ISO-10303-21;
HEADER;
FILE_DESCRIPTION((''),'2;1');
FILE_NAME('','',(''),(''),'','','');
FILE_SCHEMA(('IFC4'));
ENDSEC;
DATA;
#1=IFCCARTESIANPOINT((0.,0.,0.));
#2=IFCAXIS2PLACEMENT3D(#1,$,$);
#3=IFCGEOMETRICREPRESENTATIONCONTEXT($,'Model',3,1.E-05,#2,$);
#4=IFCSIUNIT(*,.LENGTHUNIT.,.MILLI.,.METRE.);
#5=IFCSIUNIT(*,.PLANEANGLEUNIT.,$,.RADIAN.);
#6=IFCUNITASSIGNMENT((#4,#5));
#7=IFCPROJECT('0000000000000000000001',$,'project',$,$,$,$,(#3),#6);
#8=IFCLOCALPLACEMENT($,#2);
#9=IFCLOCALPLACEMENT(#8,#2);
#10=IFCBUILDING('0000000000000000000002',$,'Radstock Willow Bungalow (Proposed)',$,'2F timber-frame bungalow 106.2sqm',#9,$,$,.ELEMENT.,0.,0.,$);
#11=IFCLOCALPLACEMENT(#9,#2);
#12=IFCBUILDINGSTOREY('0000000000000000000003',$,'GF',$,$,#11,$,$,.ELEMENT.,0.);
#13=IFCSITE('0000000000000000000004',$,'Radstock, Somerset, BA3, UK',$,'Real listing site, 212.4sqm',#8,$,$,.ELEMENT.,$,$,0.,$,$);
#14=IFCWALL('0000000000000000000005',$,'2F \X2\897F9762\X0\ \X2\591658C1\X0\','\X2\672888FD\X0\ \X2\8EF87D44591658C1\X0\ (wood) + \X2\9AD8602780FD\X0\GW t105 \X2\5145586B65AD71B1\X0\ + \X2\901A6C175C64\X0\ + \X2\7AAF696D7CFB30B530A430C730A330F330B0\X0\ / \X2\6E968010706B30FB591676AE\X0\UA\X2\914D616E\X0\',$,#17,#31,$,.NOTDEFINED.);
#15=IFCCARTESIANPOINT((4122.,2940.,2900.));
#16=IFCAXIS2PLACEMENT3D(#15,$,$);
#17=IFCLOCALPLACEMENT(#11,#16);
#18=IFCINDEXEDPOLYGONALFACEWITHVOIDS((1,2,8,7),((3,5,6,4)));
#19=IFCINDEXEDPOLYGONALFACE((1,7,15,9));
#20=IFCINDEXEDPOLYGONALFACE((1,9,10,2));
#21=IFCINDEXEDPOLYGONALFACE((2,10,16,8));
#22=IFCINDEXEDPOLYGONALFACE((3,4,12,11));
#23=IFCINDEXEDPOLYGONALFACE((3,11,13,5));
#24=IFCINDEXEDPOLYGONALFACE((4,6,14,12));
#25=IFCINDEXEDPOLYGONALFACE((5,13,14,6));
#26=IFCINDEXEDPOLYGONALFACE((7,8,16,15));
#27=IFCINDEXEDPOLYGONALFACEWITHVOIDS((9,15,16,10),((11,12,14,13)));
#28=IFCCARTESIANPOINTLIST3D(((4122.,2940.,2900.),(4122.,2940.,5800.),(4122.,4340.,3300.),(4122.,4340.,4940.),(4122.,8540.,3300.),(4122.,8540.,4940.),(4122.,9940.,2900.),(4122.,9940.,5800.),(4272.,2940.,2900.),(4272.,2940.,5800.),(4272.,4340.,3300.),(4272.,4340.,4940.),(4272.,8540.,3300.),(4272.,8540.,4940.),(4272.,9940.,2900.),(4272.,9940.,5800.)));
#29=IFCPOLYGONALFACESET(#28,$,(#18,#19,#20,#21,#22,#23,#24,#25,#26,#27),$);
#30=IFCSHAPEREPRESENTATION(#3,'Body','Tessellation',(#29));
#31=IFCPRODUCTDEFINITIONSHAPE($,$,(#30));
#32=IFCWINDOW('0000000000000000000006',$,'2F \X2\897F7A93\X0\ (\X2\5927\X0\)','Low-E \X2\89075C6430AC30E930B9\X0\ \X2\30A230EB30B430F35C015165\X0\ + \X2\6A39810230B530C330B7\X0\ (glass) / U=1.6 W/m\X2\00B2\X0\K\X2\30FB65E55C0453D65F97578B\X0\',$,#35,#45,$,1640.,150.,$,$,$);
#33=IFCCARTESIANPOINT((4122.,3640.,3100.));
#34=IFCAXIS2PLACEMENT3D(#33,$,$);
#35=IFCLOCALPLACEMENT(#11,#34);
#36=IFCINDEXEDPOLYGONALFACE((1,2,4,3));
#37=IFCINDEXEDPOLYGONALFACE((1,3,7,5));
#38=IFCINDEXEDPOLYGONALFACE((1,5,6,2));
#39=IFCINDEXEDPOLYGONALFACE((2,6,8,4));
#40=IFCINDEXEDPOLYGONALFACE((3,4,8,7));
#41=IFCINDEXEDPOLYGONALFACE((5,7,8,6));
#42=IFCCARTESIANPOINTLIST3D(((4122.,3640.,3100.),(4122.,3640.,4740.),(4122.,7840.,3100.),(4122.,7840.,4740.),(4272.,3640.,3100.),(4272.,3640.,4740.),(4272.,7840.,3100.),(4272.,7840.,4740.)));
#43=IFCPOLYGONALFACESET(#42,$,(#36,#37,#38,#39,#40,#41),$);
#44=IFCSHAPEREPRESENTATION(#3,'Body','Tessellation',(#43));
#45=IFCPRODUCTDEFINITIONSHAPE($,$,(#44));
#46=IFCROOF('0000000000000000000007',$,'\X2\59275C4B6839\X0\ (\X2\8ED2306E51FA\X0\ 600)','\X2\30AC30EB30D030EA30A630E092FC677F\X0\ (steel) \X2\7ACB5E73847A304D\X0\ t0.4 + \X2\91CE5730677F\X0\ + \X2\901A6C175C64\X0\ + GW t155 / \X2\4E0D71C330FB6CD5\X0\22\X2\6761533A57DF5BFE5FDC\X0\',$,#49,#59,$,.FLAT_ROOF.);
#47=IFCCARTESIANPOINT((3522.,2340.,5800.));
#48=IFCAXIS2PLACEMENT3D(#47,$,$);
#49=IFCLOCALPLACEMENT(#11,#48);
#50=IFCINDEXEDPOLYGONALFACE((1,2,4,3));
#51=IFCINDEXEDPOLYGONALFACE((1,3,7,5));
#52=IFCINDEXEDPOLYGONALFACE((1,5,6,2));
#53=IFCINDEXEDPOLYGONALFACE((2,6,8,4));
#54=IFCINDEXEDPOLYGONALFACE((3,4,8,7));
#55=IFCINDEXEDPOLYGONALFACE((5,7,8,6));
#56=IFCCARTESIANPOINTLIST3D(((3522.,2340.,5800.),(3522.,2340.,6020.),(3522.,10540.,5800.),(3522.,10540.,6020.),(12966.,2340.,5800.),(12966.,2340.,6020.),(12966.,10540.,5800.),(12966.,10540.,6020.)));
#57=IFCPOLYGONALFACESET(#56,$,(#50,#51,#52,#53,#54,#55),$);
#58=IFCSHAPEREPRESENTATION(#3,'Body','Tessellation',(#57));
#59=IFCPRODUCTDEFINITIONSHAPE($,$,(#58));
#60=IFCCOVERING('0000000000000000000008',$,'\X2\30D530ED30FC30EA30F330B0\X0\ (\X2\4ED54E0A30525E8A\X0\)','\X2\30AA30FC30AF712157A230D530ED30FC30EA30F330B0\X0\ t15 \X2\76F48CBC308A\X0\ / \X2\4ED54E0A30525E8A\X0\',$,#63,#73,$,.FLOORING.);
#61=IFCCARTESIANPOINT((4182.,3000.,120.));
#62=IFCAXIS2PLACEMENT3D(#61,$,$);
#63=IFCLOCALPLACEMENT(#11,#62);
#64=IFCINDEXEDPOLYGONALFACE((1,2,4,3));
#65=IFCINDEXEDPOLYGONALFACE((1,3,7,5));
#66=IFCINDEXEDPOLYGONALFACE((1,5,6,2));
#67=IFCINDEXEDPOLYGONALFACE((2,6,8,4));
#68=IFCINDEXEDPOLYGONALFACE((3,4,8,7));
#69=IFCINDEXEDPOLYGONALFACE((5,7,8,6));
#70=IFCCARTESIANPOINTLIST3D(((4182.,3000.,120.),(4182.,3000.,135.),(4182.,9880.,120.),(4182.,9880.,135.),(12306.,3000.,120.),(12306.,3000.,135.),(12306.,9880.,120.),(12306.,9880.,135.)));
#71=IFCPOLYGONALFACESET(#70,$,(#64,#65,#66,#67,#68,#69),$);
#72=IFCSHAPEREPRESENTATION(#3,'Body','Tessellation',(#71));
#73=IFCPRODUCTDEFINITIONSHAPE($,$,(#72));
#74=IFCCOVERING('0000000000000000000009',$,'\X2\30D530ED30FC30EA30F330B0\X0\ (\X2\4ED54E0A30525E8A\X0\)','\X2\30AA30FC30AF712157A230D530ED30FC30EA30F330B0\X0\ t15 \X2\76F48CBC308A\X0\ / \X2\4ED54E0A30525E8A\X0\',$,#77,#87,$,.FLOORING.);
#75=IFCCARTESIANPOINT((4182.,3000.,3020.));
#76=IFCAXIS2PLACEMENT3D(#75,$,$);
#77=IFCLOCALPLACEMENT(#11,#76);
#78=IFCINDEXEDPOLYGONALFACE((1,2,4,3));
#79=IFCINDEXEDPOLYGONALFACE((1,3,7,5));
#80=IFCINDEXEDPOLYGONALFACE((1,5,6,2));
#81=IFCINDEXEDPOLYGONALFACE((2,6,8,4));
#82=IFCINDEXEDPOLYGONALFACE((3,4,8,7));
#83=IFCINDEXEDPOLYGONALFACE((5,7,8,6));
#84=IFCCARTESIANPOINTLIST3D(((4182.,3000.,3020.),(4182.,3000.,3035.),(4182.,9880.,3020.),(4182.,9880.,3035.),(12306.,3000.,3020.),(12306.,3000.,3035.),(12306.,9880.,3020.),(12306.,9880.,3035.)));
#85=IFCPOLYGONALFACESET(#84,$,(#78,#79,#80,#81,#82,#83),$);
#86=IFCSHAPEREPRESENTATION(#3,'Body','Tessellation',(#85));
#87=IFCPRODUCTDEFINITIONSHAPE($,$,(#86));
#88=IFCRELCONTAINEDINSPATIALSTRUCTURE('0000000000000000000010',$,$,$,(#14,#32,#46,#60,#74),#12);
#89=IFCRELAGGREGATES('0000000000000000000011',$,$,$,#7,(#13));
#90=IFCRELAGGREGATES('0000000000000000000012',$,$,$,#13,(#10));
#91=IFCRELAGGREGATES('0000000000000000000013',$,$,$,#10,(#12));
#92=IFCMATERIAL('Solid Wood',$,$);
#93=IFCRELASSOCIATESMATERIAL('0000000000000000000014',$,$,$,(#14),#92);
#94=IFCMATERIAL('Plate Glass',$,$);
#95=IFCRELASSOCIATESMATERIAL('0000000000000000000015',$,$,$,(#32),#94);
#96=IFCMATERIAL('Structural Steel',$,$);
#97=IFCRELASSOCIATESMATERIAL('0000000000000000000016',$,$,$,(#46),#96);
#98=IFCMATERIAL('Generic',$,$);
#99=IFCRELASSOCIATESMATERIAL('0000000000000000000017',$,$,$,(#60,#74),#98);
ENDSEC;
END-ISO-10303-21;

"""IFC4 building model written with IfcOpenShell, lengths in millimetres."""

from ifc_helpers import new_model, si_unit, frame, frame_2d, origin, place, context, project, spatial, rectangle, extrude, material, element, fill, save


model = new_model("IFC4")

# Units and contexts
model_context = context("Model", 3, precision=1e-05, world=origin())
ifc_project = project(units=[si_unit("LENGTHUNIT", "METRE", prefix="MILLI"), si_unit("PLANEANGLEUNIT", "RADIAN")], contexts=[model_context])

# Site, building, storey
site_placement = place(None, origin())
site = spatial("IfcSite", under=ifc_project, at=site_placement, Name="Radstock, Somerset, BA3, UK", ObjectType="Real listing site, 212.4sqm", CompositionType="ELEMENT", RefElevation=0.0)
building_placement = place(site_placement, origin())
building = spatial("IfcBuilding", under=site, at=building_placement, Name="Radstock Willow Bungalow (Proposed)", ObjectType="2F timber-frame bungalow 106.2sqm", CompositionType="ELEMENT", ElevationOfRefHeight=0.0, ElevationOfTerrain=0.0)
storey_placement = place(building_placement, origin())
storey = spatial("IfcBuildingStorey", under=building, at=storey_placement, Name="GF", CompositionType="ELEMENT", Elevation=0.0)

# Shared definitions
ifc_material_1 = material(Name="Solid Wood")

# Shared definitions
ifc_material_2 = material(Name="Plate Glass")

# Wall, opening, window
wall_1_placement = place(storey_placement, frame((4122.0, 2940.0, 2900.0)))
wall_1 = element("IfcWall", 1, at=wall_1_placement, inside=storey, material=ifc_material_1, Name="2F 西面 外壁", Description="木製 軸組外壁 (wood) + 高性能GW t105 充填断熱 + 通気層 + 窯業系サイディング / 準耐火・外皮UA配慮", PredefinedType="NOTDEFINED", context=model_context, shape_type="SweptSolid", body=[
    extrude(rectangle(XDim=150.0, YDim=7000.0, at=frame_2d((75.0, 3500.0))), frame((4122.0, 2940.0, 2900.0)), (0.0, 0.0, 1.0), 2900.0),
])
opening_1_placement = place(storey_placement, frame((4122.0, 3640.0, 3100.0)))
opening_1 = element("IfcOpeningElement", 2, at=opening_1_placement, cuts=wall_1, PredefinedType="NOTDEFINED", context=model_context, shape_type="SweptSolid", body=[
    extrude(rectangle(XDim=150.0, YDim=4200.0, at=frame_2d((75.0, 2100.0))), frame((4122.0, 3640.0, 3100.0)), (0.0, 0.0, 1.0), 1640.0),
])
window_1_placement = place(storey_placement, frame((4122.0, 3640.0, 3100.0)))
window_1 = element("IfcWindow", 3, at=window_1_placement, inside=storey, material=ifc_material_2, Name="2F 西窓 (大)", Description="Low-E 複層ガラス アルゴン封入 + 樹脂サッシ (glass) / U=1.6 W/m²K・日射取得型", OverallHeight=1640.0, OverallWidth=150.0, context=model_context, shape_type="SweptSolid", body=[
    extrude(rectangle(XDim=150.0, YDim=4200.0, at=frame_2d((75.0, 2100.0))), frame((4122.0, 3640.0, 3100.0)), (0.0, 0.0, 1.0), 1640.0),
])
fill(opening_1, window_1)

# Roof
ifc_material_3 = material(Name="Structural Steel")
roof_placement = place(storey_placement, frame((3522.0, 2340.0, 5800.0)))
element("IfcRoof", 4, at=roof_placement, inside=storey, material=ifc_material_3, Name="大屋根 (軒の出 600)", Description="ガルバリウム鋼板 (steel) 立平葺き t0.4 + 野地板 + 通気層 + GW t155 / 不燃・法22条区域対応", PredefinedType="FLAT_ROOF", context=model_context, shape_type="SweptSolid", body=[
    extrude(rectangle(XDim=9444.0, YDim=8200.0, at=frame_2d((4722.0, 4100.0))), frame((3522.0, 2340.0, 5800.0)), (0.0, 0.0, 1.0), 220.0),
])

# Coverings
ifc_material_4 = material(Name="Generic")
covering_1_placement = place(storey_placement, frame((4182.0, 3000.0, 120.0)))
element("IfcCovering", 5, at=covering_1_placement, inside=storey, material=ifc_material_4, Name="フローリング (仕上げ床)", Description="オーク無垢フローリング t15 直貼り / 仕上げ床", PredefinedType="FLOORING", context=model_context, shape_type="SweptSolid", body=[
    extrude(rectangle(XDim=8124.0, YDim=6880.0, at=frame_2d((4062.0, 3440.0))), frame((4182.0, 3000.0, 120.0)), (0.0, 0.0, 1.0), 15.0),
])
covering_2_placement = place(storey_placement, frame((4182.0, 3000.0, 3020.0)))
element("IfcCovering", 6, at=covering_2_placement, inside=storey, material=ifc_material_4, Name="フローリング (仕上げ床)", Description="オーク無垢フローリング t15 直貼り / 仕上げ床", PredefinedType="FLOORING", context=model_context, shape_type="SweptSolid", body=[
    extrude(rectangle(XDim=8124.0, YDim=6880.0, at=frame_2d((4062.0, 3440.0))), frame((4182.0, 3000.0, 3020.0)), (0.0, 0.0, 1.0), 15.0),
])

save(model, "model.ifc")
